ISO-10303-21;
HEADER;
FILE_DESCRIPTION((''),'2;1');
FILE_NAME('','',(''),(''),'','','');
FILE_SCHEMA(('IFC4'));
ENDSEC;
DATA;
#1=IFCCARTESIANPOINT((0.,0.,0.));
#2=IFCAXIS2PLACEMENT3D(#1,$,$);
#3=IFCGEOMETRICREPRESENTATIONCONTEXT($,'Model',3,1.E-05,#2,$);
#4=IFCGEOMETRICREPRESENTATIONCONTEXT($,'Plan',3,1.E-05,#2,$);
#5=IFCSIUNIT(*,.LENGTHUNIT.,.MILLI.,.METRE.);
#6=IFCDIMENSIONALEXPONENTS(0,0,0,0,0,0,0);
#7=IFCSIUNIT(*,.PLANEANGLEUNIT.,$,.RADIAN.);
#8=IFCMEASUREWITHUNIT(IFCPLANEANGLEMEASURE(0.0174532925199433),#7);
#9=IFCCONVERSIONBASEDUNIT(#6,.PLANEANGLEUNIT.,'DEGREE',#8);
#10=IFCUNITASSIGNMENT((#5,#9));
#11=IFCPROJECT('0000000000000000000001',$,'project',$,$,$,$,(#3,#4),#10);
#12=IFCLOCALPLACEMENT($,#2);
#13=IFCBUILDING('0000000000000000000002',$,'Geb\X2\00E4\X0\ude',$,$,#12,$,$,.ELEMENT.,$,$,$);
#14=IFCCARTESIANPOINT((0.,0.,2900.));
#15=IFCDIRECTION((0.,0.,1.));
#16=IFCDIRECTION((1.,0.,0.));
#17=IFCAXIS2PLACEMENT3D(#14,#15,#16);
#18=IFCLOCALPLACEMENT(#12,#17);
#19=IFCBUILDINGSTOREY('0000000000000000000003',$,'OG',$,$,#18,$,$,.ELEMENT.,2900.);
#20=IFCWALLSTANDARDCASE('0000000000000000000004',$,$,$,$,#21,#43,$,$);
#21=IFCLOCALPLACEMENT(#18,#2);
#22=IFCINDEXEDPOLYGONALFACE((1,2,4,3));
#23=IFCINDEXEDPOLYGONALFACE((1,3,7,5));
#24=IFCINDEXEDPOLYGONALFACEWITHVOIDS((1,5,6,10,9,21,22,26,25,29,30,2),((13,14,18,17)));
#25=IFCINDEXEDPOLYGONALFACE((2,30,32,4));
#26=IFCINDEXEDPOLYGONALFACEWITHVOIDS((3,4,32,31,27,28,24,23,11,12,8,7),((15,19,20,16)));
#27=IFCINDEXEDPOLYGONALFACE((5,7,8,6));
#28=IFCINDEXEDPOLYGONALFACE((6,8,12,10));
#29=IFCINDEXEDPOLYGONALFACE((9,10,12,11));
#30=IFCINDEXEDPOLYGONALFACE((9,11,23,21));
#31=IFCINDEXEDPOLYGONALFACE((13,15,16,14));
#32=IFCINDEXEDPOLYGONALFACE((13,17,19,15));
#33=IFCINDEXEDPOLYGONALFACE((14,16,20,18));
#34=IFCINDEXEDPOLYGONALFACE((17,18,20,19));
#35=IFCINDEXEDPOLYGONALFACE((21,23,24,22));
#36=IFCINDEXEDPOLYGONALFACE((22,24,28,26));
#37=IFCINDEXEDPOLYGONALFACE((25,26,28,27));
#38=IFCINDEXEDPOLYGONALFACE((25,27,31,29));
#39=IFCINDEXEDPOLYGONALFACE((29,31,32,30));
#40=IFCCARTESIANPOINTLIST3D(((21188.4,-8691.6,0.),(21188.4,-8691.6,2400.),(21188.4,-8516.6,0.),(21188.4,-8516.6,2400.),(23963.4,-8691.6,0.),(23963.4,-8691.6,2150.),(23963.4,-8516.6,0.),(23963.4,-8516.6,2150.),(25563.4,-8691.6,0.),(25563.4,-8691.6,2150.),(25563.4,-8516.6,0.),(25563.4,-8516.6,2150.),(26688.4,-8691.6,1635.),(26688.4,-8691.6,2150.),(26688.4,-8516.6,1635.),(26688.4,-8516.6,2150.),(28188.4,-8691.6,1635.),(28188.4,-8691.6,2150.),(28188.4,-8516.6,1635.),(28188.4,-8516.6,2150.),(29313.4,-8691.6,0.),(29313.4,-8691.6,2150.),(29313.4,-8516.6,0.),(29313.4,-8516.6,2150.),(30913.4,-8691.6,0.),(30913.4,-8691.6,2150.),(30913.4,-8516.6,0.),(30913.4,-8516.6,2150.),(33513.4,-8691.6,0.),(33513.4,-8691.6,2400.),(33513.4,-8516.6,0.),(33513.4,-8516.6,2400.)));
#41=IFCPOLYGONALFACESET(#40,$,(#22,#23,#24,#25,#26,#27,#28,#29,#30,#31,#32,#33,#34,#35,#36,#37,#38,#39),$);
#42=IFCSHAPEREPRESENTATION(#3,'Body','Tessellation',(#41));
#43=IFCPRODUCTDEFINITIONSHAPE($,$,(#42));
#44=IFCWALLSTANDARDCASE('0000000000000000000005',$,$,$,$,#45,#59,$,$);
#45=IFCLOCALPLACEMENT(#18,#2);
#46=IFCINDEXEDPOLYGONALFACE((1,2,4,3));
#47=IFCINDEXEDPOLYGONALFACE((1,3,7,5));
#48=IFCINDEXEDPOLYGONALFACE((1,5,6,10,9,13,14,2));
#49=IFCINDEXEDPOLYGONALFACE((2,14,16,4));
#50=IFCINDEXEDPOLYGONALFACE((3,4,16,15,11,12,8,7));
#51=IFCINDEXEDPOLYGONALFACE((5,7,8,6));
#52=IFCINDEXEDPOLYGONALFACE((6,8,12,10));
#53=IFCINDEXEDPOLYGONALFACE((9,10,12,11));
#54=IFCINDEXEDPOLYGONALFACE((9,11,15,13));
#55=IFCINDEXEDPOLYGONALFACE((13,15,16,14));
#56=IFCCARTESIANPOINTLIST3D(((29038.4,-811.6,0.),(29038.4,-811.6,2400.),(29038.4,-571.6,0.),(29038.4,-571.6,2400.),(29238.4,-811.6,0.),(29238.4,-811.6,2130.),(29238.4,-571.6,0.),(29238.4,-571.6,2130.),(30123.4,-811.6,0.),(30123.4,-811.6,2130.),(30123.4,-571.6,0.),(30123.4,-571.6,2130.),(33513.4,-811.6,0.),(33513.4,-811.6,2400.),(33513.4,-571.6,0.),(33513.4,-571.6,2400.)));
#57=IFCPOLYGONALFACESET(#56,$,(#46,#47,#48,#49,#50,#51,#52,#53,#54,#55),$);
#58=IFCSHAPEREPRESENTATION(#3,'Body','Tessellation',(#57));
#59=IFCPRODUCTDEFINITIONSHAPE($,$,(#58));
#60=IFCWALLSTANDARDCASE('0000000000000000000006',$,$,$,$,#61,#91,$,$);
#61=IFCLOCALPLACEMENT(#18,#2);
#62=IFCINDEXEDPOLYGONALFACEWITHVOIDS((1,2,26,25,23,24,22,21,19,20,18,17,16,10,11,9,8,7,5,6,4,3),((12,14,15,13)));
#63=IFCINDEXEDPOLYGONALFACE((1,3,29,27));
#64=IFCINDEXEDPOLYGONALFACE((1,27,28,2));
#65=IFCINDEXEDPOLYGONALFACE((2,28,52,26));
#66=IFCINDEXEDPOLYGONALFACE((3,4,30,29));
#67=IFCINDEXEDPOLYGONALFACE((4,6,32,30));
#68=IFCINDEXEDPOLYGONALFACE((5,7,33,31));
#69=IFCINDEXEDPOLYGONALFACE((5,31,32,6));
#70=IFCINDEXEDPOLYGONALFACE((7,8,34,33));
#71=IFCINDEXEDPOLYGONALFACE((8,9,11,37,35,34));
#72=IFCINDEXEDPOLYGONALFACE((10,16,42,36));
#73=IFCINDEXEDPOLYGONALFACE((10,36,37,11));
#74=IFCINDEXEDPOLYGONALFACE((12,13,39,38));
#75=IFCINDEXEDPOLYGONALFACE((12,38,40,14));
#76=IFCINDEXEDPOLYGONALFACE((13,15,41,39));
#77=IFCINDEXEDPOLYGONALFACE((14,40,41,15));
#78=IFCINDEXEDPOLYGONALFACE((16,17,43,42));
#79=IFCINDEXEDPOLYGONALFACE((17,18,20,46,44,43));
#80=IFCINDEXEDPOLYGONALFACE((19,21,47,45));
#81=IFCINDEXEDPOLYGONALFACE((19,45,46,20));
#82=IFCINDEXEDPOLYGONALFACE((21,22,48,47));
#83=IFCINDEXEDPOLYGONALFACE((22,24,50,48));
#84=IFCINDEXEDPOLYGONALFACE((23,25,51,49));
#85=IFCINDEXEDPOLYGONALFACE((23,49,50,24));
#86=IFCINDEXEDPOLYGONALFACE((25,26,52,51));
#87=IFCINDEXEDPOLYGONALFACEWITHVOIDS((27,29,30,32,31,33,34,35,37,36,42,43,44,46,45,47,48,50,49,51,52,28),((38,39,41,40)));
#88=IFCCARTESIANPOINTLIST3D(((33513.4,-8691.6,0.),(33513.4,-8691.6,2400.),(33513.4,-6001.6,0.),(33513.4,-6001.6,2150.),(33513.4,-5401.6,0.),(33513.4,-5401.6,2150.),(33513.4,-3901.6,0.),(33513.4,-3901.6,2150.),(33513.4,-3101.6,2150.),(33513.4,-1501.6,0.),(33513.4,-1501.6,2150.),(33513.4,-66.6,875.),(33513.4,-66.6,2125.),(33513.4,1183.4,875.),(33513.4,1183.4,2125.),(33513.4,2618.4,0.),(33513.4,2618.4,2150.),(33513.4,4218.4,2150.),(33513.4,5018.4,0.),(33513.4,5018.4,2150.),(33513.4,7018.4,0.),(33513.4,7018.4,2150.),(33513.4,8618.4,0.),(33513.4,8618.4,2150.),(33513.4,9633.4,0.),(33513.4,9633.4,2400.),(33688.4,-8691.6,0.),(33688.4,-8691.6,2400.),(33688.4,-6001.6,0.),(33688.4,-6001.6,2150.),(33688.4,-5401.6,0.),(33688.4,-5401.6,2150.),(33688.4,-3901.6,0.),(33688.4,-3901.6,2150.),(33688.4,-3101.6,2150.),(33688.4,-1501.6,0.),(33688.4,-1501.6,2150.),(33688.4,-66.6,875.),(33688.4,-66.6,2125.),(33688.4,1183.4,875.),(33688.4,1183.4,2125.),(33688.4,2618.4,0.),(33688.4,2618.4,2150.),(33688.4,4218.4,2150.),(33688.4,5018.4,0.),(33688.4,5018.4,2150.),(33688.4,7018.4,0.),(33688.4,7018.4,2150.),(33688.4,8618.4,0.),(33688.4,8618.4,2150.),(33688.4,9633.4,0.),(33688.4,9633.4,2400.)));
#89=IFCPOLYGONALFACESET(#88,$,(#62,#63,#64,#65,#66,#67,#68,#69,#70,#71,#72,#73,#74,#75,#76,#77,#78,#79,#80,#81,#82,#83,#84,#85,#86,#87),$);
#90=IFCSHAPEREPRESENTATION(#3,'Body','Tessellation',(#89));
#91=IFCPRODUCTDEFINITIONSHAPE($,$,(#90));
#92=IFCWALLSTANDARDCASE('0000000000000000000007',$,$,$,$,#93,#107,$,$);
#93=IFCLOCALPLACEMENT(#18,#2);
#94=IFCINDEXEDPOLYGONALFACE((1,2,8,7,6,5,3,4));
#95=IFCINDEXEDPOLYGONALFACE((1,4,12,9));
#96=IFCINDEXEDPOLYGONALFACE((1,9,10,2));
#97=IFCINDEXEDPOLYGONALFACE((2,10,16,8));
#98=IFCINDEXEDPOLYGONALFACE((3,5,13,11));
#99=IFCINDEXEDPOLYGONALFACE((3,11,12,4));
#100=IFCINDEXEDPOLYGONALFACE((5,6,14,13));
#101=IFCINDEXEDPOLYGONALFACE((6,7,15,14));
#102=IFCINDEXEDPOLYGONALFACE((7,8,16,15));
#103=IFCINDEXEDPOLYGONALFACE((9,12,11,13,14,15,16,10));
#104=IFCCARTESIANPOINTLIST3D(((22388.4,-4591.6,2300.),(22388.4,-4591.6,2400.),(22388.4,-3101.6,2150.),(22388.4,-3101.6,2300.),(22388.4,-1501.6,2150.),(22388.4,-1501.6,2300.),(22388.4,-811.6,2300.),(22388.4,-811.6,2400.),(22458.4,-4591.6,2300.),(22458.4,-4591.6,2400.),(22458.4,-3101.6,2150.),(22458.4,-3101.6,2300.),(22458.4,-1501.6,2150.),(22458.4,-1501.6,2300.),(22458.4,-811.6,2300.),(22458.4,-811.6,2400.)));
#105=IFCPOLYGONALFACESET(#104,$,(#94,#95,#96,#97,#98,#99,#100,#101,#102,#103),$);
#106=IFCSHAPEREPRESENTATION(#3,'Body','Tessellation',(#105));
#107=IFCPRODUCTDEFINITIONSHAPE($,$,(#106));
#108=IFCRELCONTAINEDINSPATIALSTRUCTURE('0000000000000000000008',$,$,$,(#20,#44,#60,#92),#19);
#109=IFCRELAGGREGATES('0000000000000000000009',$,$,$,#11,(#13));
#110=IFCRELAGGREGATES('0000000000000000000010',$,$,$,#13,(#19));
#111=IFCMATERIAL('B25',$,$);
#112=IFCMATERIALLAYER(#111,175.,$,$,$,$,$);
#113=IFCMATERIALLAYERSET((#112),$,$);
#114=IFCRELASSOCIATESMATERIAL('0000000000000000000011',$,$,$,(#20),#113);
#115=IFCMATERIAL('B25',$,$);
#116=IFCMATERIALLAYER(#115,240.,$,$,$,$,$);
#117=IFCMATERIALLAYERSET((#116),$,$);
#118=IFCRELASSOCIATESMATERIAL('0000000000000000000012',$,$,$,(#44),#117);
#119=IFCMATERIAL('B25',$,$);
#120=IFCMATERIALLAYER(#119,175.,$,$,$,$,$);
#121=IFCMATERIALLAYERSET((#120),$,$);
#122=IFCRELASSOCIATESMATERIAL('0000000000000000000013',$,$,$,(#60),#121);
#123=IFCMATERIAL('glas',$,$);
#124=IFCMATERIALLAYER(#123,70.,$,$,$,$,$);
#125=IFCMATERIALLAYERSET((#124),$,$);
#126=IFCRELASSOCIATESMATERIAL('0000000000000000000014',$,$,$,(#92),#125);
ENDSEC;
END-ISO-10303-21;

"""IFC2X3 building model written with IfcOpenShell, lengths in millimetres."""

from ifc_helpers import new_model, entity, si_unit, converted_unit, frame, frame_2d, origin, origin_with_axes, place, context, project, spatial, rectangle, extrude, material, layer, layer_set, layer_usage, element, save


model = new_model("IFC2X3")

# Units and contexts
model_context = context("Model", 3, precision=1e-05, world=origin())
plan_context = context("Plan", 3, precision=1e-05, world=origin())
ifc_project = project(units=[si_unit("LENGTHUNIT", "METRE", prefix="MILLI"), converted_unit("PLANEANGLEUNIT", "DEGREE", entity("IfcPlaneAngleMeasure", 0.0174532925199433), si_unit("PLANEANGLEUNIT", "RADIAN"), dimensions=[0, 0, 0, 0, 0, 0, 0])], contexts=[model_context, plan_context])

# Building, storey
building_placement = place(None, origin())
building = spatial("IfcBuilding", under=ifc_project, at=building_placement, Name="Gebäude", CompositionType="ELEMENT")
storey_placement = place(building_placement, frame((0.0, 0.0, 2900.0), z_axis=(0.0, 0.0, 1.0), x_axis=(1.0, 0.0, 0.0)))
storey = spatial("IfcBuildingStorey", under=building, at=storey_placement, Name="OG", CompositionType="ELEMENT", Elevation=2900.0)

# Wall, openings
ifc_material_1 = material(Name="B25")
ifc_layer_1 = layer(ifc_material_1, 175.0)
ifc_layer_set_1 = layer_set([ifc_layer_1])
ifc_layer_usage_1 = layer_usage(ifc_layer_set_1, "AXIS2", "POSITIVE", 0.0)
wall_1_placement = place(storey_placement, frame((21188.4, -8691.6, 0.0), z_axis=(0.0, 0.0, 1.0), x_axis=(1.0, 0.0, 0.0)))
wall_1 = element("IfcWallStandardCase", 1, at=wall_1_placement, inside=storey, material=ifc_layer_usage_1, context=model_context, shape_type="SweptSolid", body=[
    extrude(rectangle(XDim=12325.0, YDim=175.0, at=frame_2d((6162.5, 87.5), x_axis=(1.0, 0.0))), origin_with_axes(), (0.0, 0.0, 1.0), 2400.0),
])
opening_1_placement = place(wall_1_placement, frame((5500.0, 0.0, 1635.0), z_axis=(0.0, 1.0, 0.0), x_axis=(0.0, 0.0, 1.0)))
element("IfcOpeningElement", 2, at=opening_1_placement, cuts=wall_1, ObjectType="Opening", context=model_context, shape_type="SweptSolid", body=[
    extrude(rectangle(XDim=515.0, YDim=1500.0, at=frame_2d((257.5, 750.0), x_axis=(1.0, 0.0))), origin_with_axes(), (0.0, 0.0, 1.0), 175.0),
])
opening_2_placement = place(wall_1_placement, frame((2775.0, 0.0, 0.0), z_axis=(0.0, 1.0, 0.0), x_axis=(0.0, 0.0, 1.0)))
element("IfcOpeningElement", 3, at=opening_2_placement, cuts=wall_1, ObjectType="Opening", context=model_context, shape_type="SweptSolid", body=[
    extrude(rectangle(XDim=2150.0, YDim=1600.0, at=frame_2d((1075.0, 800.0), x_axis=(1.0, 0.0))), origin_with_axes(), (0.0, 0.0, 1.0), 175.0),
])
opening_3_placement = place(wall_1_placement, frame((8125.0, 0.0, 0.0), z_axis=(0.0, 1.0, 0.0), x_axis=(0.0, 0.0, 1.0)))
element("IfcOpeningElement", 4, at=opening_3_placement, cuts=wall_1, ObjectType="Opening", context=model_context, shape_type="SweptSolid", body=[
    extrude(rectangle(XDim=2150.0, YDim=1600.0, at=frame_2d((1075.0, 800.0), x_axis=(1.0, 0.0))), origin_with_axes(), (0.0, 0.0, 1.0), 175.0),
])

# Wall, opening
ifc_material_2 = material(Name="B25")
ifc_layer_2 = layer(ifc_material_2, 240.0)
ifc_layer_set_2 = layer_set([ifc_layer_2])
ifc_layer_usage_2 = layer_usage(ifc_layer_set_2, "AXIS2", "POSITIVE", 0.0)
wall_2_placement = place(storey_placement, frame((33513.4, -571.6, 0.0), z_axis=(0.0, 0.0, 1.0), x_axis=(-1.0, 0.0, 0.0)))
wall_2 = element("IfcWallStandardCase", 5, at=wall_2_placement, inside=storey, material=ifc_layer_usage_2, context=model_context, shape_type="SweptSolid", body=[
    extrude(rectangle(XDim=4475.0, YDim=240.0, at=frame_2d((2237.5, 120.0), x_axis=(1.0, 0.0))), origin_with_axes(), (0.0, 0.0, 1.0), 2400.0),
])
opening_4_placement = place(wall_2_placement, frame((3390.0, 0.0, 0.0), z_axis=(0.0, 1.0, 0.0), x_axis=(0.0, 0.0, 1.0)))
element("IfcOpeningElement", 6, at=opening_4_placement, cuts=wall_2, ObjectType="Opening", context=model_context, shape_type="SweptSolid", body=[
    extrude(rectangle(XDim=2130.0, YDim=885.0, at=frame_2d((1065.0, 442.5), x_axis=(1.0, 0.0))), origin_with_axes(), (0.0, 0.0, 1.0), 240.0),
])

# Walls, openings
ifc_material_3 = material(Name="B25")
ifc_layer_3 = layer(ifc_material_3, 175.0)
ifc_layer_set_3 = layer_set([ifc_layer_3])
ifc_layer_usage_3 = layer_usage(ifc_layer_set_3, "AXIS2", "POSITIVE", 0.0)
wall_3_placement = place(storey_placement, frame((33688.4, -8691.6, 0.0), z_axis=(0.0, 0.0, 1.0), x_axis=(0.0, 1.0, 0.0)))
wall_3 = element("IfcWallStandardCase", 7, at=wall_3_placement, inside=storey, material=ifc_layer_usage_3, context=model_context, shape_type="SweptSolid", body=[
    extrude(rectangle(XDim=18325.0, YDim=175.0, at=frame_2d((9162.5, 87.5), x_axis=(1.0, 0.0))), origin_with_axes(), (0.0, 0.0, 1.0), 2400.0),
])
opening_5_placement = place(wall_3_placement, frame((2690.0, 0.0, 0.0), z_axis=(0.0, 1.0, 0.0), x_axis=(0.0, 0.0, 1.0)))
element("IfcOpeningElement", 8, at=opening_5_placement, cuts=wall_3, ObjectType="Opening", context=model_context, shape_type="SweptSolid", body=[
    extrude(rectangle(XDim=2150.0, YDim=600.0, at=frame_2d((1075.0, 300.0), x_axis=(1.0, 0.0))), origin_with_axes(), (0.0, 0.0, 1.0), 175.0),
])
opening_6_placement = place(wall_3_placement, frame((5590.0, 0.0, 0.0), z_axis=(0.0, 1.0, 0.0), x_axis=(0.0, 0.0, 1.0)))
element("IfcOpeningElement", 9, at=opening_6_placement, cuts=wall_3, ObjectType="Opening", context=model_context, shape_type="SweptSolid", body=[
    extrude(rectangle(XDim=2150.0, YDim=1600.0, at=frame_2d((1075.0, 800.0), x_axis=(1.0, 0.0))), origin_with_axes(), (0.0, 0.0, 1.0), 175.0),
])
opening_7_placement = place(wall_3_placement, frame((15710.0, 0.0, 0.0), z_axis=(0.0, 1.0, 0.0), x_axis=(0.0, 0.0, 1.0)))
element("IfcOpeningElement", 10, at=opening_7_placement, cuts=wall_3, ObjectType="Opening", context=model_context, shape_type="SweptSolid", body=[
    extrude(rectangle(XDim=2150.0, YDim=1600.0, at=frame_2d((1075.0, 800.0), x_axis=(1.0, 0.0))), origin_with_axes(), (0.0, 0.0, 1.0), 175.0),
])
opening_8_placement = place(wall_3_placement, frame((8625.0, 0.0, 875.0), z_axis=(0.0, 1.0, 0.0), x_axis=(0.0, 0.0, 1.0)))
element("IfcOpeningElement", 11, at=opening_8_placement, cuts=wall_3, ObjectType="Opening", context=model_context, shape_type="SweptSolid", body=[
    extrude(rectangle(XDim=1250.0, YDim=1250.0, at=frame_2d((625.0, 625.0), x_axis=(1.0, 0.0))), origin_with_axes(), (0.0, 0.0, 1.0), 175.0),
])
opening_9_placement = place(wall_3_placement, frame((4790.0, 0.0, 0.0), z_axis=(0.0, 1.0, 0.0), x_axis=(0.0, 0.0, 1.0)))
element("IfcOpeningElement", 12, at=opening_9_placement, cuts=wall_3, ObjectType="Opening", context=model_context, shape_type="SweptSolid", body=[
    extrude(rectangle(XDim=2150.0, YDim=800.0, at=frame_2d((1075.0, 400.0), x_axis=(1.0, 0.0))), origin_with_axes(), (0.0, 0.0, 1.0), 175.0),
])
opening_10_placement = place(wall_3_placement, frame((12910.0, 0.0, 0.0), z_axis=(0.0, 1.0, 0.0), x_axis=(0.0, 0.0, 1.0)))
element("IfcOpeningElement", 13, at=opening_10_placement, cuts=wall_3, ObjectType="Opening", context=model_context, shape_type="SweptSolid", body=[
    extrude(rectangle(XDim=2150.0, YDim=800.0, at=frame_2d((1075.0, 400.0), x_axis=(1.0, 0.0))), origin_with_axes(), (0.0, 0.0, 1.0), 175.0),
])
opening_11_placement = place(wall_3_placement, frame((11310.0, 0.0, 0.0), z_axis=(0.0, 1.0, 0.0), x_axis=(0.0, 0.0, 1.0)))
element("IfcOpeningElement", 14, at=opening_11_placement, cuts=wall_3, ObjectType="Opening", context=model_context, shape_type="SweptSolid", body=[
    extrude(rectangle(XDim=2150.0, YDim=1600.0, at=frame_2d((1075.0, 800.0), x_axis=(1.0, 0.0))), origin_with_axes(), (0.0, 0.0, 1.0), 175.0),
])
ifc_material_4 = material(Name="glas")
ifc_layer_4 = layer(ifc_material_4, 70.0)
ifc_layer_set_4 = layer_set([ifc_layer_4])
ifc_layer_usage_4 = layer_usage(ifc_layer_set_4, "AXIS2", "POSITIVE", 0.0)
wall_4_placement = place(storey_placement, frame((22458.4, -4591.6, 0.0), z_axis=(0.0, 0.0, 1.0), x_axis=(0.0, 1.0, 0.0)))
wall_4 = element("IfcWallStandardCase", 15, at=wall_4_placement, inside=storey, material=ifc_layer_usage_4, context=model_context, shape_type="SweptSolid", body=[
    extrude(rectangle(XDim=3780.0, YDim=70.0, at=frame_2d((1890.0, 35.0), x_axis=(1.0, 0.0))), origin_with_axes(), (0.0, 0.0, 1.0), 2400.0),
])
opening_12_placement = place(wall_4_placement, frame((1490.0, 0.0, 0.0), z_axis=(0.0, 1.0, 0.0), x_axis=(0.0, 0.0, 1.0)))
element("IfcOpeningElement", 16, at=opening_12_placement, cuts=wall_4, ObjectType="Opening", context=model_context, shape_type="SweptSolid", body=[
    extrude(rectangle(XDim=2150.0, YDim=1600.0, at=frame_2d((1075.0, 800.0), x_axis=(1.0, 0.0))), origin_with_axes(), (0.0, 0.0, 1.0), 70.0),
])
opening_13_placement = place(wall_4_placement, frame((3090.0, 0.0, 0.0), z_axis=(0.0, 1.0, 0.0), x_axis=(0.0, 0.0, 1.0)))
element("IfcOpeningElement", 17, at=opening_13_placement, cuts=wall_4, ObjectType="Opening", context=model_context, shape_type="SweptSolid", body=[
    extrude(rectangle(XDim=2300.0, YDim=690.0, at=frame_2d((1150.0, 345.0), x_axis=(1.0, 0.0))), origin_with_axes(), (0.0, 0.0, 1.0), 70.0),
])
opening_14_placement = place(wall_4_placement, frame((0.0, 0.0, 0.0), z_axis=(0.0, 1.0, 0.0), x_axis=(0.0, 0.0, 1.0)))
element("IfcOpeningElement", 18, at=opening_14_placement, cuts=wall_4, ObjectType="Opening", context=model_context, shape_type="SweptSolid", body=[
    extrude(rectangle(XDim=2300.0, YDim=1490.0, at=frame_2d((1150.0, 745.0), x_axis=(1.0, 0.0))), origin_with_axes(), (0.0, 0.0, 1.0), 70.0),
])

save(model, "model.ifc")
